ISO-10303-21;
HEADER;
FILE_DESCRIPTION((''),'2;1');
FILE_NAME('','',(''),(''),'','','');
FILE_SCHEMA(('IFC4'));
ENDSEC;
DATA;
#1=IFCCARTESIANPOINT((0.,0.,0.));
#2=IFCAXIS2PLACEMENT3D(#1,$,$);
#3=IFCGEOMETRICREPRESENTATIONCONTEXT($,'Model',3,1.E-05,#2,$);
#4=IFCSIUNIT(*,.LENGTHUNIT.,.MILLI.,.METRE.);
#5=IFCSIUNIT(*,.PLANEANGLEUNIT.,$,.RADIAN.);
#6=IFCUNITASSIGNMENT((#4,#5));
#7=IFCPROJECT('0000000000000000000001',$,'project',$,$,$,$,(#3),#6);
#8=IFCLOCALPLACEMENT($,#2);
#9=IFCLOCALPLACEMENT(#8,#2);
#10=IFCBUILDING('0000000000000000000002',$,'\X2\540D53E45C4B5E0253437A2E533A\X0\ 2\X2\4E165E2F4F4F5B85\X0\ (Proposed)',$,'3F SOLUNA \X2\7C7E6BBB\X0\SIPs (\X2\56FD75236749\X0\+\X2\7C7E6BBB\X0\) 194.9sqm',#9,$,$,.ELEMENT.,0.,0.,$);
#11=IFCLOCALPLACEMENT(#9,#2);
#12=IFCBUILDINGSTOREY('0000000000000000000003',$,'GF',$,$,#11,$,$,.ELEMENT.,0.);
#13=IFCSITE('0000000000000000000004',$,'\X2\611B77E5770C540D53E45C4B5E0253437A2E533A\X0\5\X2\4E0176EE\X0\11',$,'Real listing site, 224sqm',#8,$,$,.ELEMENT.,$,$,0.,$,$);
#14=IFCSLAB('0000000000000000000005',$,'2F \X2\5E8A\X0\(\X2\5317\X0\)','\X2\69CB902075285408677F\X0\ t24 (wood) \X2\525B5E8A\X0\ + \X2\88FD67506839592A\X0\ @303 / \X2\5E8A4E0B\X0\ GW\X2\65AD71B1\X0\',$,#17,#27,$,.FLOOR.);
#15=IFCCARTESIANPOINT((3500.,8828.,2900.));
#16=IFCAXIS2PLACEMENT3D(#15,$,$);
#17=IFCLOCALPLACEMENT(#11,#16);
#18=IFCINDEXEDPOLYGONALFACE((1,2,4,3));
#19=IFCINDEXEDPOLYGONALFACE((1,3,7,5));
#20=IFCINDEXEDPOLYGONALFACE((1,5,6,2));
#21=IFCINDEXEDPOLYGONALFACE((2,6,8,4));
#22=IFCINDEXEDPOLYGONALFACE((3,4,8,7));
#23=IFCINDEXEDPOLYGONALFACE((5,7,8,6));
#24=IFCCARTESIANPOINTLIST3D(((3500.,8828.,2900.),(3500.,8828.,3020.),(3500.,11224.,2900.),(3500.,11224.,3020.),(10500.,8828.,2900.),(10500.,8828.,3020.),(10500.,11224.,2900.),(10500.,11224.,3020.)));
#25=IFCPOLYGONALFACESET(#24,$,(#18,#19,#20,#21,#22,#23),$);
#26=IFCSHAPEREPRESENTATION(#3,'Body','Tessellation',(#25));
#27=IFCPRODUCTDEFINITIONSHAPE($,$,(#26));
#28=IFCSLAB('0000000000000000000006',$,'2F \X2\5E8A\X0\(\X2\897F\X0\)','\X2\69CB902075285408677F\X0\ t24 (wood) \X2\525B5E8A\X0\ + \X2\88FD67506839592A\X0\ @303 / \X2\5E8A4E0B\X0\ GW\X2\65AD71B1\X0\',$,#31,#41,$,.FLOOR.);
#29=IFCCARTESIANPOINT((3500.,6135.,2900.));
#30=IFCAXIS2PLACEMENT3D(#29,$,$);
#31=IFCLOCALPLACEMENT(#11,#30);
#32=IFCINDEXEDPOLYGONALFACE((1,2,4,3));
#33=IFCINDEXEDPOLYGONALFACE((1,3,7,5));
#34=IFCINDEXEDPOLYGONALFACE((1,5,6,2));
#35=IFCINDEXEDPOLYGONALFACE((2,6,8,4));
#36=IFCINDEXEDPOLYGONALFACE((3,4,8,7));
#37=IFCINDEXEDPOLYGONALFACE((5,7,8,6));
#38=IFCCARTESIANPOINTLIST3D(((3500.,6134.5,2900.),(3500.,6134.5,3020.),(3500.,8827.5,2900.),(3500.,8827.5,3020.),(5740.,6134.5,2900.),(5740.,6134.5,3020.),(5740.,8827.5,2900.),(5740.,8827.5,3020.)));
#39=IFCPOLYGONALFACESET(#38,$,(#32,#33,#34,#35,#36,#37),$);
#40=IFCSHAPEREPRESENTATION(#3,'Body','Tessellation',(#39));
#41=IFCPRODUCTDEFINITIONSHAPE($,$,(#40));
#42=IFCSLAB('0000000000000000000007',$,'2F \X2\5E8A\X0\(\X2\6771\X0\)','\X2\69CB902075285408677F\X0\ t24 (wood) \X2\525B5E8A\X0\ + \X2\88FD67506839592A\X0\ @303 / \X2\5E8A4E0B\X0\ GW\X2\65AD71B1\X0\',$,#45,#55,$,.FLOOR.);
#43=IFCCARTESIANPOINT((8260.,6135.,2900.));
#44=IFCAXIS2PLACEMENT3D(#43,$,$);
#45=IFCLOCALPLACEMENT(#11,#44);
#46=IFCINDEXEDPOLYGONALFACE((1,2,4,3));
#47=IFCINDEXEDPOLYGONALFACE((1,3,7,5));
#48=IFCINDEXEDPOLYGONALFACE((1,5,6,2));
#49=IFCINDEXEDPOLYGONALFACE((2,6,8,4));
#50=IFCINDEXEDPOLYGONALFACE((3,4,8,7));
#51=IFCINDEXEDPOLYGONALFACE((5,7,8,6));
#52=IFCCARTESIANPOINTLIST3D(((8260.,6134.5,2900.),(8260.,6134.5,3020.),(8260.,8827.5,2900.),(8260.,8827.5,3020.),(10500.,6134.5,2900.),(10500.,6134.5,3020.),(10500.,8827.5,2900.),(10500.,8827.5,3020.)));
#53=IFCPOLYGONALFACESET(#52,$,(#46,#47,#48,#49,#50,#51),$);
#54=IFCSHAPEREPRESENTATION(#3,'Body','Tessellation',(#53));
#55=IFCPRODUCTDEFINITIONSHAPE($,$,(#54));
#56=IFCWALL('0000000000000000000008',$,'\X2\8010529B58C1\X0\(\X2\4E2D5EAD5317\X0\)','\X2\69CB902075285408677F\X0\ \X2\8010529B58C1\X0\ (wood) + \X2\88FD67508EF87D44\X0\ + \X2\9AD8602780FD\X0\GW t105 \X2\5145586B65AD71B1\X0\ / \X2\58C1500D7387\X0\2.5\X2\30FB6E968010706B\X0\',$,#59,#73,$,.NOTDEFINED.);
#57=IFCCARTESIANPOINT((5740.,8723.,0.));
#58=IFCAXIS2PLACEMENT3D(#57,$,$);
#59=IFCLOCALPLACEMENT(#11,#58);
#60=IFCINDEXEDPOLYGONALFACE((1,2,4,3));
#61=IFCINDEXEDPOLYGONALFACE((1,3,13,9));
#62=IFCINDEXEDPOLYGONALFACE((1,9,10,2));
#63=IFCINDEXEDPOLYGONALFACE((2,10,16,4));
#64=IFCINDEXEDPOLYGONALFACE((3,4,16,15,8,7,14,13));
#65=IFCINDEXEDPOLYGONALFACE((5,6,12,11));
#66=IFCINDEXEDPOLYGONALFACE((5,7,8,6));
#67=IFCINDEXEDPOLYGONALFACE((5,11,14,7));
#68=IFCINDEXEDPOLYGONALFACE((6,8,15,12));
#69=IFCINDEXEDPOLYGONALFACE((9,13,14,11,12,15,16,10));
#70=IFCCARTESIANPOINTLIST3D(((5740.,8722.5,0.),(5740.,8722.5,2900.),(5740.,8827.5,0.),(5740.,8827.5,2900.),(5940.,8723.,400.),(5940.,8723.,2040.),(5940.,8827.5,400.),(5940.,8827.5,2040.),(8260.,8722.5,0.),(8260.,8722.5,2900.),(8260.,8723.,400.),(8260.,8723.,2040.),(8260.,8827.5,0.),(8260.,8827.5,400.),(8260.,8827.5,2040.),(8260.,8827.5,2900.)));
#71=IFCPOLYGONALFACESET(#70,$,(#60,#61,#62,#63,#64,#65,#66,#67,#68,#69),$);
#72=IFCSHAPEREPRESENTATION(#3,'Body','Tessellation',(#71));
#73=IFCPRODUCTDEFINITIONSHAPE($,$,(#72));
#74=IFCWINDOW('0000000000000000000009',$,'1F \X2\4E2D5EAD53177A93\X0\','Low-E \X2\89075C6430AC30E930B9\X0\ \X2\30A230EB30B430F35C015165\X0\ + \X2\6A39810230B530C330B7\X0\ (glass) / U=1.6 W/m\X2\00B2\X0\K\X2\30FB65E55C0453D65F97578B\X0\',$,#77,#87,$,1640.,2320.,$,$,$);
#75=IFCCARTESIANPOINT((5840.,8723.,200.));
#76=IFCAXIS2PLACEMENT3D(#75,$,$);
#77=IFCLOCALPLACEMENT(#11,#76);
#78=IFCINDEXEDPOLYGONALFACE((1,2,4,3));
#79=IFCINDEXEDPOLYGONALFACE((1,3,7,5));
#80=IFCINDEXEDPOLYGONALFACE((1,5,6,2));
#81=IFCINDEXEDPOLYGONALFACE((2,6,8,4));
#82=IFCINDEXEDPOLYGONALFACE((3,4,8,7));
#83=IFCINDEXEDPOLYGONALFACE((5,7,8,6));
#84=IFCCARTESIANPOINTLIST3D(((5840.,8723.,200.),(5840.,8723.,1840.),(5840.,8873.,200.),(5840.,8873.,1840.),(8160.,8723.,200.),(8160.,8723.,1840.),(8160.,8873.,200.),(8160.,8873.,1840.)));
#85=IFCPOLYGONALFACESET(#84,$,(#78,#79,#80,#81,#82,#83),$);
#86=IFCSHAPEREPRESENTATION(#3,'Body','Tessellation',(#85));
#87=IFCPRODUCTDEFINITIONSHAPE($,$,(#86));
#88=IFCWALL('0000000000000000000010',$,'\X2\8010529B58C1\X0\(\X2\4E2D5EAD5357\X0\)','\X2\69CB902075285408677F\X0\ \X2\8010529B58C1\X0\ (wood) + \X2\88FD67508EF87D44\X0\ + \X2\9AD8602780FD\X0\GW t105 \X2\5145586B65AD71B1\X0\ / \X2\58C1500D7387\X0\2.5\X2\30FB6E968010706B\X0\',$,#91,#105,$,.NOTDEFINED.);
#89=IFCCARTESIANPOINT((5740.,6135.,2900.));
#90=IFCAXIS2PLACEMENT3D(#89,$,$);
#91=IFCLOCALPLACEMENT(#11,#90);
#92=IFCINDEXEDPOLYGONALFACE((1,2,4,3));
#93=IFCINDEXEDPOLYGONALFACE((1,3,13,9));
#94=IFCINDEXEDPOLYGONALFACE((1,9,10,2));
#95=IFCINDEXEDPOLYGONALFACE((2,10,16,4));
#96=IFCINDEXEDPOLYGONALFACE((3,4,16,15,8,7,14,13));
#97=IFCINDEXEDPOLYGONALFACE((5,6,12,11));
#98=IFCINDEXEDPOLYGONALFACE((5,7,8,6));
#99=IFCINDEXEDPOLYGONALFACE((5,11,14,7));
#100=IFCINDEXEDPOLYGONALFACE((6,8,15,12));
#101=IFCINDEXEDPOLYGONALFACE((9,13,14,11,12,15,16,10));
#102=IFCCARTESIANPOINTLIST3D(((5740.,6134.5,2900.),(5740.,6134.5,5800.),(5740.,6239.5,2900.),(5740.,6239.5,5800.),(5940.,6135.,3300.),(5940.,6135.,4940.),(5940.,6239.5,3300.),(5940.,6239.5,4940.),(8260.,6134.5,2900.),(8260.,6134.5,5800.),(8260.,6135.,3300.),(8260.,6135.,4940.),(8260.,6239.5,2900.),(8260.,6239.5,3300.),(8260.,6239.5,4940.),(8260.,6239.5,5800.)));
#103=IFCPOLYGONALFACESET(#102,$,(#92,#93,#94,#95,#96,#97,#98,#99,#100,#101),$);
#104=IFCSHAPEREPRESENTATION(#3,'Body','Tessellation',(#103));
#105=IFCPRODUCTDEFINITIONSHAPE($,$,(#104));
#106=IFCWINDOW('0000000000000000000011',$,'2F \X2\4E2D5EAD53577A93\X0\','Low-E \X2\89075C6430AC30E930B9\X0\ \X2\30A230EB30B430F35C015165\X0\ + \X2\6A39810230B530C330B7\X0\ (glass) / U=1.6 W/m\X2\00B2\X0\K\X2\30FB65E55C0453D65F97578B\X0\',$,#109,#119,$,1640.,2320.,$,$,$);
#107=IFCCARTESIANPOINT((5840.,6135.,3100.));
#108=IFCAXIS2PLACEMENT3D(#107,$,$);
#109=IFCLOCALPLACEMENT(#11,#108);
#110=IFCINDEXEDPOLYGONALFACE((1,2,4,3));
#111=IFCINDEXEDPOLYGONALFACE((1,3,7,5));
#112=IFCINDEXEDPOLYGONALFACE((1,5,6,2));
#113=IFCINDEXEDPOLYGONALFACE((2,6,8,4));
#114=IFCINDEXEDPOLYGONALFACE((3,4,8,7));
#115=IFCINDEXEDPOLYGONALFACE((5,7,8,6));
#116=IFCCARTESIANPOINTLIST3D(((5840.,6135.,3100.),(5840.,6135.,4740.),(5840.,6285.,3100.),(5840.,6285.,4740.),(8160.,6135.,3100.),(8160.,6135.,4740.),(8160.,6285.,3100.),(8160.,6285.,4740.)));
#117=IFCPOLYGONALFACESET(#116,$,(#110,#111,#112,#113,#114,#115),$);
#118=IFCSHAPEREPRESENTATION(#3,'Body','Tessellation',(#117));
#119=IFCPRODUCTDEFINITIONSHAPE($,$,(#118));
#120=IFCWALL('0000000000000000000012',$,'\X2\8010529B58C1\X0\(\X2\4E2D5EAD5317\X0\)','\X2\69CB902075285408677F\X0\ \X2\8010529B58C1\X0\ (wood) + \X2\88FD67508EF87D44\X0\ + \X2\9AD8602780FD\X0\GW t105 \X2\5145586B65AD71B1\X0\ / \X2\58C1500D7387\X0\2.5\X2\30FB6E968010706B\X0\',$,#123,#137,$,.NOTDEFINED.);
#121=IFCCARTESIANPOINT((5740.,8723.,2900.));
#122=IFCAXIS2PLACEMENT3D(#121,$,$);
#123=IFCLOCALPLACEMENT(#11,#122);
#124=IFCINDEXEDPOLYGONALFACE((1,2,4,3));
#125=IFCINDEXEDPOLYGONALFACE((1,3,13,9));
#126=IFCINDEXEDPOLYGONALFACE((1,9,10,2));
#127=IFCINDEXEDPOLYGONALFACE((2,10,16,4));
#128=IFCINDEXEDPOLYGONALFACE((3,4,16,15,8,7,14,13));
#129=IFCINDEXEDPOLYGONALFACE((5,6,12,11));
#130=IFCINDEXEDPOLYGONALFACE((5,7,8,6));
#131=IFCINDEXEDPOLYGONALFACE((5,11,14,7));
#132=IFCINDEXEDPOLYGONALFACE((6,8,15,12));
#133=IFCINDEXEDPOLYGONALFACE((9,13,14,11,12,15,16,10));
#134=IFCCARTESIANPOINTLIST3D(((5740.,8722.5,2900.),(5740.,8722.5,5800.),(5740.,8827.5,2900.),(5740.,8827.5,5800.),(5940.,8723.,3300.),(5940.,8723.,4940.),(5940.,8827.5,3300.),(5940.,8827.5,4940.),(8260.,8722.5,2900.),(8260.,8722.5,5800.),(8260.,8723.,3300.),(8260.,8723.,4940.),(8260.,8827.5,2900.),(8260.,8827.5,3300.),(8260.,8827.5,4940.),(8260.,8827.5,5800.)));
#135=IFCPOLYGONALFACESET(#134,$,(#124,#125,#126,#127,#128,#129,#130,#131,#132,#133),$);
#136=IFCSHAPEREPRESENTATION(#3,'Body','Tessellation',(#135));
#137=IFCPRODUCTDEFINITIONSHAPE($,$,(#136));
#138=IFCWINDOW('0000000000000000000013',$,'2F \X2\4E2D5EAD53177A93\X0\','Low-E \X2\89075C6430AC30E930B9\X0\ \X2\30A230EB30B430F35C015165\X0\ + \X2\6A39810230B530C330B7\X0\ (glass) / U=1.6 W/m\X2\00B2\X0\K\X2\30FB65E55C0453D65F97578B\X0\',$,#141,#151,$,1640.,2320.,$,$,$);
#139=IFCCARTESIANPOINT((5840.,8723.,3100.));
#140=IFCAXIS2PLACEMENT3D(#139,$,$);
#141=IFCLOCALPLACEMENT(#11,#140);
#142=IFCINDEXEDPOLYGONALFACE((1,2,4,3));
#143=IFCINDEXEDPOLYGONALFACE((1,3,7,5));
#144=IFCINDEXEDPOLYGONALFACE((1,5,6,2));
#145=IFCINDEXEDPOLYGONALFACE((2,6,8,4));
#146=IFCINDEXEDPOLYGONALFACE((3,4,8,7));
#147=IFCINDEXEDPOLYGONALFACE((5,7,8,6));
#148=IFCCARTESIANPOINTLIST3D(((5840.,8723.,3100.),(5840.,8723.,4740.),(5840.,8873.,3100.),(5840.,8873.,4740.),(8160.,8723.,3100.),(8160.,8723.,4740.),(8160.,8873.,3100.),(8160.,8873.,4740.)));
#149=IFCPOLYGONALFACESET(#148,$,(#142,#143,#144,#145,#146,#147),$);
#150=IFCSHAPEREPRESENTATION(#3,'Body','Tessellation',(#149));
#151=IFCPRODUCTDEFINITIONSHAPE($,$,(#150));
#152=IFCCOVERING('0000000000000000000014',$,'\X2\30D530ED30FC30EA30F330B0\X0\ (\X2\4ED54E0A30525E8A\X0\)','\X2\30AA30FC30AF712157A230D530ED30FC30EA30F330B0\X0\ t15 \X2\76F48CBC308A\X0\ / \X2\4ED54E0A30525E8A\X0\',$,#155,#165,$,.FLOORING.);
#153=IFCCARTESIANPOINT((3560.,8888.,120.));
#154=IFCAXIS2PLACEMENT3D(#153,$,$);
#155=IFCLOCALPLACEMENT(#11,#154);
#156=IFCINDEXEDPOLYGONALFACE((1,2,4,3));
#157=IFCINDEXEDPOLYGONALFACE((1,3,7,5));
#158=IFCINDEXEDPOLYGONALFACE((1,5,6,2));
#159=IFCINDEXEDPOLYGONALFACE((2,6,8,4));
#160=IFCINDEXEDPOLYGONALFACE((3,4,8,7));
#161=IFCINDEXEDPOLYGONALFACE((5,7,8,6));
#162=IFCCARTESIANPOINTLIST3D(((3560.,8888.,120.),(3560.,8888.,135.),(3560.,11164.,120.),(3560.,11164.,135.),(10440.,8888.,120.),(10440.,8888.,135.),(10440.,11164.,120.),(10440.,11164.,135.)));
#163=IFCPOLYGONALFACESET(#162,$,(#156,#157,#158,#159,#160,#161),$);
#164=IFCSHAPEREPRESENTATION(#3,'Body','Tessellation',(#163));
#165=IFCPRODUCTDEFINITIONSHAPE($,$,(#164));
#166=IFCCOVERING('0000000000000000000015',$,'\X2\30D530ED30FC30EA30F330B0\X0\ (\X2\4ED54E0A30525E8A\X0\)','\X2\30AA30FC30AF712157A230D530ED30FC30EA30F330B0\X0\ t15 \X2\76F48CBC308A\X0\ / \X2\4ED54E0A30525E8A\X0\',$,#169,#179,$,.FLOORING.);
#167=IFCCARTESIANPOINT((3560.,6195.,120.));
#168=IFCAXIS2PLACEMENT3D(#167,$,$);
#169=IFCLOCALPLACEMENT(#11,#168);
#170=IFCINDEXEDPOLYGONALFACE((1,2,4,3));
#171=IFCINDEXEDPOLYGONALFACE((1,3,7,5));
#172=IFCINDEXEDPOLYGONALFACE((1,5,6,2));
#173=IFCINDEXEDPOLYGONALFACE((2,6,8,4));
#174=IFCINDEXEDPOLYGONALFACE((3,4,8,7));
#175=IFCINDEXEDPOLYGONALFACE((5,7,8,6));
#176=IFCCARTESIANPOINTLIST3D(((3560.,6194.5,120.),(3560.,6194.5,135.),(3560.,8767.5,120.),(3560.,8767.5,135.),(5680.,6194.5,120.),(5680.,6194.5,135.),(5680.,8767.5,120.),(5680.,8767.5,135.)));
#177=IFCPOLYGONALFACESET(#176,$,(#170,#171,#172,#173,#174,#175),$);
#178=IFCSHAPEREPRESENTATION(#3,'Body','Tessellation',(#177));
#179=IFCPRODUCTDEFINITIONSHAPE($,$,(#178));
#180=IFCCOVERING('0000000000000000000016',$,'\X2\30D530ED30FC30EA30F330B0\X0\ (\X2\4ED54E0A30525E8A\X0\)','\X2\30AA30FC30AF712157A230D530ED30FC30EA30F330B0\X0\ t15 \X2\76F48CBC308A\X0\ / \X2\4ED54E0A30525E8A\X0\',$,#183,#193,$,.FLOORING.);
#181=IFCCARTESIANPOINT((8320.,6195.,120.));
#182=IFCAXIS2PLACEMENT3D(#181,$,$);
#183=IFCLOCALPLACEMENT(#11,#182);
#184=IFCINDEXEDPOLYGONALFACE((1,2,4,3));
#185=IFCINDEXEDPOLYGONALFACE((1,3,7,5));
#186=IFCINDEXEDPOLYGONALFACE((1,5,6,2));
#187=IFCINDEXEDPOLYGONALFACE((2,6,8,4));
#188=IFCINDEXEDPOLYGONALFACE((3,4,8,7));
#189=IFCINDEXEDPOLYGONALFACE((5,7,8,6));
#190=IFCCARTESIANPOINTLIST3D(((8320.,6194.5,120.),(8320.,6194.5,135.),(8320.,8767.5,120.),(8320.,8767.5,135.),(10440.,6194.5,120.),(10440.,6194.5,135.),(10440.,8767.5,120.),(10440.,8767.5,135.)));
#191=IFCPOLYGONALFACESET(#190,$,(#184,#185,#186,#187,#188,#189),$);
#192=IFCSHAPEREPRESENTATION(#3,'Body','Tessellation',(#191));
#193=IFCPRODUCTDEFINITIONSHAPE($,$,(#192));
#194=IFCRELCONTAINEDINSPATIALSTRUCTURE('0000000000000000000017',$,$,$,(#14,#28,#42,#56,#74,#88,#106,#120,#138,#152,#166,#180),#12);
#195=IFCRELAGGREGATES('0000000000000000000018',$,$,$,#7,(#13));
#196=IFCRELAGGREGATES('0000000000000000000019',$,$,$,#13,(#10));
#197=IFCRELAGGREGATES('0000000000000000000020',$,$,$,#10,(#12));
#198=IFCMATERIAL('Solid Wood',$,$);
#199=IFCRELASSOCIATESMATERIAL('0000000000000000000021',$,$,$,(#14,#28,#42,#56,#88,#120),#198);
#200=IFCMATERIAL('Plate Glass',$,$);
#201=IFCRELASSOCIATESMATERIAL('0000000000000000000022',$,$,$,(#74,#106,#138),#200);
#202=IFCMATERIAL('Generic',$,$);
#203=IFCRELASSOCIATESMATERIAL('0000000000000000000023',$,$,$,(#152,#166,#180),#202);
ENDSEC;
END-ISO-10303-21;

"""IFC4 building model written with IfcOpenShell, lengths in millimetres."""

from ifc_helpers import new_model, si_unit, frame, frame_2d, origin, place, context, project, spatial, rectangle, extrude, material, element, fill, save


model = new_model("IFC4")

# Units and contexts
model_context = context("Model", 3, precision=1e-05, world=origin())
ifc_project = project(units=[si_unit("LENGTHUNIT", "METRE", prefix="MILLI"), si_unit("PLANEANGLEUNIT", "RADIAN")], contexts=[model_context])

# Site, building, storey
site_placement = place(None, origin())
site = spatial("IfcSite", under=ifc_project, at=site_placement, Name="愛知県名古屋市千種区5丁目11", ObjectType="Real listing site, 224sqm", CompositionType="ELEMENT", RefElevation=0.0)
building_placement = place(site_placement, origin())
building = spatial("IfcBuilding", under=site, at=building_placement, Name="名古屋市千種区 2世帯住宅 (Proposed)", ObjectType="3F SOLUNA 籾殻SIPs (国産杉+籾殻) 194.9sqm", CompositionType="ELEMENT", ElevationOfRefHeight=0.0, ElevationOfTerrain=0.0)
storey_placement = place(building_placement, origin())
storey = spatial("IfcBuildingStorey", under=building, at=storey_placement, Name="GF", CompositionType="ELEMENT", Elevation=0.0)

# Slabs
ifc_material_1 = material(Name="Solid Wood")
slab_1_placement = place(storey_placement, frame((3500.0, 8828.0, 2900.0)))
element("IfcSlab", 1, at=slab_1_placement, inside=storey, material=ifc_material_1, Name="2F 床(北)", Description="構造用合板 t24 (wood) 剛床 + 製材根太 @303 / 床下 GW断熱", PredefinedType="FLOOR", context=model_context, shape_type="SweptSolid", body=[
    extrude(rectangle(XDim=7000.0, YDim=2396.0, at=frame_2d((3500.0, 1198.0))), frame((3500.0, 8828.0, 2900.0)), (0.0, 0.0, 1.0), 120.0),
])
slab_2_placement = place(storey_placement, frame((3500.0, 6135.0, 2900.0)))
element("IfcSlab", 2, at=slab_2_placement, inside=storey, material=ifc_material_1, Name="2F 床(西)", Description="構造用合板 t24 (wood) 剛床 + 製材根太 @303 / 床下 GW断熱", PredefinedType="FLOOR", context=model_context, shape_type="SweptSolid", body=[
    extrude(rectangle(XDim=2240.0, YDim=2693.0, at=frame_2d((1120.0, 1346.0))), frame((3500.0, 6135.0, 2900.0)), (0.0, 0.0, 1.0), 120.0),
])
slab_3_placement = place(storey_placement, frame((8260.0, 6135.0, 2900.0)))
element("IfcSlab", 3, at=slab_3_placement, inside=storey, material=ifc_material_1, Name="2F 床(東)", Description="構造用合板 t24 (wood) 剛床 + 製材根太 @303 / 床下 GW断熱", PredefinedType="FLOOR", context=model_context, shape_type="SweptSolid", body=[
    extrude(rectangle(XDim=2240.0, YDim=2693.0, at=frame_2d((1120.0, 1346.0))), frame((8260.0, 6135.0, 2900.0)), (0.0, 0.0, 1.0), 120.0),
])

# Wall, opening, window
wall_1_placement = place(storey_placement, frame((5740.0, 8723.0, 0.0)))
wall_1 = element("IfcWall", 4, at=wall_1_placement, inside=storey, material=ifc_material_1, Name="耐力壁(中庭北)", Description="構造用合板 耐力壁 (wood) + 製材軸組 + 高性能GW t105 充填断熱 / 壁倍率2.5・準耐火", PredefinedType="NOTDEFINED", context=model_context, shape_type="SweptSolid", body=[
    extrude(rectangle(XDim=2520.0, YDim=105.0, at=frame_2d((1260.0, 52.0))), frame((5740.0, 8723.0, 0.0)), (0.0, 0.0, 1.0), 2900.0),
])
opening_1_placement = place(storey_placement, frame((5840.0, 8723.0, 200.0)))
opening_1 = element("IfcOpeningElement", 5, at=opening_1_placement, cuts=wall_1, PredefinedType="NOTDEFINED", context=model_context, shape_type="SweptSolid", body=[
    extrude(rectangle(XDim=2320.0, YDim=150.0, at=frame_2d((1160.0, 75.0))), frame((5840.0, 8723.0, 200.0)), (0.0, 0.0, 1.0), 1640.0),
])
ifc_material_2 = material(Name="Plate Glass")
window_1_placement = place(storey_placement, frame((5840.0, 8723.0, 200.0)))
window_1 = element("IfcWindow", 6, at=window_1_placement, inside=storey, material=ifc_material_2, Name="1F 中庭北窓", Description="Low-E 複層ガラス アルゴン封入 + 樹脂サッシ (glass) / U=1.6 W/m²K・日射取得型", OverallHeight=1640.0, OverallWidth=2320.0, context=model_context, shape_type="SweptSolid", body=[
    extrude(rectangle(XDim=2320.0, YDim=150.0, at=frame_2d((1160.0, 75.0))), frame((5840.0, 8723.0, 200.0)), (0.0, 0.0, 1.0), 1640.0),
])
fill(opening_1, window_1)

# Walls, openings, windows
wall_2_placement = place(storey_placement, frame((5740.0, 6135.0, 2900.0)))
wall_2 = element("IfcWall", 7, at=wall_2_placement, inside=storey, material=ifc_material_1, Name="耐力壁(中庭南)", Description="構造用合板 耐力壁 (wood) + 製材軸組 + 高性能GW t105 充填断熱 / 壁倍率2.5・準耐火", PredefinedType="NOTDEFINED", context=model_context, shape_type="SweptSolid", body=[
    extrude(rectangle(XDim=2520.0, YDim=105.0, at=frame_2d((1260.0, 52.0))), frame((5740.0, 6135.0, 2900.0)), (0.0, 0.0, 1.0), 2900.0),
])
opening_2_placement = place(storey_placement, frame((5840.0, 6135.0, 3100.0)))
opening_2 = element("IfcOpeningElement", 8, at=opening_2_placement, cuts=wall_2, PredefinedType="NOTDEFINED", context=model_context, shape_type="SweptSolid", body=[
    extrude(rectangle(XDim=2320.0, YDim=150.0, at=frame_2d((1160.0, 75.0))), frame((5840.0, 6135.0, 3100.0)), (0.0, 0.0, 1.0), 1640.0),
])
window_2_placement = place(storey_placement, frame((5840.0, 6135.0, 3100.0)))
window_2 = element("IfcWindow", 9, at=window_2_placement, inside=storey, material=ifc_material_2, Name="2F 中庭南窓", Description="Low-E 複層ガラス アルゴン封入 + 樹脂サッシ (glass) / U=1.6 W/m²K・日射取得型", OverallHeight=1640.0, OverallWidth=2320.0, context=model_context, shape_type="SweptSolid", body=[
    extrude(rectangle(XDim=2320.0, YDim=150.0, at=frame_2d((1160.0, 75.0))), frame((5840.0, 6135.0, 3100.0)), (0.0, 0.0, 1.0), 1640.0),
])
fill(opening_2, window_2)
wall_3_placement = place(storey_placement, frame((5740.0, 8723.0, 2900.0)))
wall_3 = element("IfcWall", 10, at=wall_3_placement, inside=storey, material=ifc_material_1, Name="耐力壁(中庭北)", Description="構造用合板 耐力壁 (wood) + 製材軸組 + 高性能GW t105 充填断熱 / 壁倍率2.5・準耐火", PredefinedType="NOTDEFINED", context=model_context, shape_type="SweptSolid", body=[
    extrude(rectangle(XDim=2520.0, YDim=105.0, at=frame_2d((1260.0, 52.0))), frame((5740.0, 8723.0, 2900.0)), (0.0, 0.0, 1.0), 2900.0),
])
opening_3_placement = place(storey_placement, frame((5840.0, 8723.0, 3100.0)))
opening_3 = element("IfcOpeningElement", 11, at=opening_3_placement, cuts=wall_3, PredefinedType="NOTDEFINED", context=model_context, shape_type="SweptSolid", body=[
    extrude(rectangle(XDim=2320.0, YDim=150.0, at=frame_2d((1160.0, 75.0))), frame((5840.0, 8723.0, 3100.0)), (0.0, 0.0, 1.0), 1640.0),
])
window_3_placement = place(storey_placement, frame((5840.0, 8723.0, 3100.0)))
window_3 = element("IfcWindow", 12, at=window_3_placement, inside=storey, material=ifc_material_2, Name="2F 中庭北窓", Description="Low-E 複層ガラス アルゴン封入 + 樹脂サッシ (glass) / U=1.6 W/m²K・日射取得型", OverallHeight=1640.0, OverallWidth=2320.0, context=model_context, shape_type="SweptSolid", body=[
    extrude(rectangle(XDim=2320.0, YDim=150.0, at=frame_2d((1160.0, 75.0))), frame((5840.0, 8723.0, 3100.0)), (0.0, 0.0, 1.0), 1640.0),
])
fill(opening_3, window_3)

# Coverings
ifc_material_3 = material(Name="Generic")
covering_1_placement = place(storey_placement, frame((3560.0, 8888.0, 120.0)))
element("IfcCovering", 13, at=covering_1_placement, inside=storey, material=ifc_material_3, Name="フローリング (仕上げ床)", Description="オーク無垢フローリング t15 直貼り / 仕上げ床", PredefinedType="FLOORING", context=model_context, shape_type="SweptSolid", body=[
    extrude(rectangle(XDim=6880.0, YDim=2276.0, at=frame_2d((3440.0, 1138.0))), frame((3560.0, 8888.0, 120.0)), (0.0, 0.0, 1.0), 15.0),
])
covering_2_placement = place(storey_placement, frame((3560.0, 6195.0, 120.0)))
element("IfcCovering", 14, at=covering_2_placement, inside=storey, material=ifc_material_3, Name="フローリング (仕上げ床)", Description="オーク無垢フローリング t15 直貼り / 仕上げ床", PredefinedType="FLOORING", context=model_context, shape_type="SweptSolid", body=[
    extrude(rectangle(XDim=2120.0, YDim=2573.0, at=frame_2d((1060.0, 1286.0))), frame((3560.0, 6195.0, 120.0)), (0.0, 0.0, 1.0), 15.0),
])
covering_3_placement = place(storey_placement, frame((8320.0, 6195.0, 120.0)))
element("IfcCovering", 15, at=covering_3_placement, inside=storey, material=ifc_material_3, Name="フローリング (仕上げ床)", Description="オーク無垢フローリング t15 直貼り / 仕上げ床", PredefinedType="FLOORING", context=model_context, shape_type="SweptSolid", body=[
    extrude(rectangle(XDim=2120.0, YDim=2573.0, at=frame_2d((1060.0, 1286.0))), frame((8320.0, 6195.0, 120.0)), (0.0, 0.0, 1.0), 15.0),
])

save(model, "model.ifc")
